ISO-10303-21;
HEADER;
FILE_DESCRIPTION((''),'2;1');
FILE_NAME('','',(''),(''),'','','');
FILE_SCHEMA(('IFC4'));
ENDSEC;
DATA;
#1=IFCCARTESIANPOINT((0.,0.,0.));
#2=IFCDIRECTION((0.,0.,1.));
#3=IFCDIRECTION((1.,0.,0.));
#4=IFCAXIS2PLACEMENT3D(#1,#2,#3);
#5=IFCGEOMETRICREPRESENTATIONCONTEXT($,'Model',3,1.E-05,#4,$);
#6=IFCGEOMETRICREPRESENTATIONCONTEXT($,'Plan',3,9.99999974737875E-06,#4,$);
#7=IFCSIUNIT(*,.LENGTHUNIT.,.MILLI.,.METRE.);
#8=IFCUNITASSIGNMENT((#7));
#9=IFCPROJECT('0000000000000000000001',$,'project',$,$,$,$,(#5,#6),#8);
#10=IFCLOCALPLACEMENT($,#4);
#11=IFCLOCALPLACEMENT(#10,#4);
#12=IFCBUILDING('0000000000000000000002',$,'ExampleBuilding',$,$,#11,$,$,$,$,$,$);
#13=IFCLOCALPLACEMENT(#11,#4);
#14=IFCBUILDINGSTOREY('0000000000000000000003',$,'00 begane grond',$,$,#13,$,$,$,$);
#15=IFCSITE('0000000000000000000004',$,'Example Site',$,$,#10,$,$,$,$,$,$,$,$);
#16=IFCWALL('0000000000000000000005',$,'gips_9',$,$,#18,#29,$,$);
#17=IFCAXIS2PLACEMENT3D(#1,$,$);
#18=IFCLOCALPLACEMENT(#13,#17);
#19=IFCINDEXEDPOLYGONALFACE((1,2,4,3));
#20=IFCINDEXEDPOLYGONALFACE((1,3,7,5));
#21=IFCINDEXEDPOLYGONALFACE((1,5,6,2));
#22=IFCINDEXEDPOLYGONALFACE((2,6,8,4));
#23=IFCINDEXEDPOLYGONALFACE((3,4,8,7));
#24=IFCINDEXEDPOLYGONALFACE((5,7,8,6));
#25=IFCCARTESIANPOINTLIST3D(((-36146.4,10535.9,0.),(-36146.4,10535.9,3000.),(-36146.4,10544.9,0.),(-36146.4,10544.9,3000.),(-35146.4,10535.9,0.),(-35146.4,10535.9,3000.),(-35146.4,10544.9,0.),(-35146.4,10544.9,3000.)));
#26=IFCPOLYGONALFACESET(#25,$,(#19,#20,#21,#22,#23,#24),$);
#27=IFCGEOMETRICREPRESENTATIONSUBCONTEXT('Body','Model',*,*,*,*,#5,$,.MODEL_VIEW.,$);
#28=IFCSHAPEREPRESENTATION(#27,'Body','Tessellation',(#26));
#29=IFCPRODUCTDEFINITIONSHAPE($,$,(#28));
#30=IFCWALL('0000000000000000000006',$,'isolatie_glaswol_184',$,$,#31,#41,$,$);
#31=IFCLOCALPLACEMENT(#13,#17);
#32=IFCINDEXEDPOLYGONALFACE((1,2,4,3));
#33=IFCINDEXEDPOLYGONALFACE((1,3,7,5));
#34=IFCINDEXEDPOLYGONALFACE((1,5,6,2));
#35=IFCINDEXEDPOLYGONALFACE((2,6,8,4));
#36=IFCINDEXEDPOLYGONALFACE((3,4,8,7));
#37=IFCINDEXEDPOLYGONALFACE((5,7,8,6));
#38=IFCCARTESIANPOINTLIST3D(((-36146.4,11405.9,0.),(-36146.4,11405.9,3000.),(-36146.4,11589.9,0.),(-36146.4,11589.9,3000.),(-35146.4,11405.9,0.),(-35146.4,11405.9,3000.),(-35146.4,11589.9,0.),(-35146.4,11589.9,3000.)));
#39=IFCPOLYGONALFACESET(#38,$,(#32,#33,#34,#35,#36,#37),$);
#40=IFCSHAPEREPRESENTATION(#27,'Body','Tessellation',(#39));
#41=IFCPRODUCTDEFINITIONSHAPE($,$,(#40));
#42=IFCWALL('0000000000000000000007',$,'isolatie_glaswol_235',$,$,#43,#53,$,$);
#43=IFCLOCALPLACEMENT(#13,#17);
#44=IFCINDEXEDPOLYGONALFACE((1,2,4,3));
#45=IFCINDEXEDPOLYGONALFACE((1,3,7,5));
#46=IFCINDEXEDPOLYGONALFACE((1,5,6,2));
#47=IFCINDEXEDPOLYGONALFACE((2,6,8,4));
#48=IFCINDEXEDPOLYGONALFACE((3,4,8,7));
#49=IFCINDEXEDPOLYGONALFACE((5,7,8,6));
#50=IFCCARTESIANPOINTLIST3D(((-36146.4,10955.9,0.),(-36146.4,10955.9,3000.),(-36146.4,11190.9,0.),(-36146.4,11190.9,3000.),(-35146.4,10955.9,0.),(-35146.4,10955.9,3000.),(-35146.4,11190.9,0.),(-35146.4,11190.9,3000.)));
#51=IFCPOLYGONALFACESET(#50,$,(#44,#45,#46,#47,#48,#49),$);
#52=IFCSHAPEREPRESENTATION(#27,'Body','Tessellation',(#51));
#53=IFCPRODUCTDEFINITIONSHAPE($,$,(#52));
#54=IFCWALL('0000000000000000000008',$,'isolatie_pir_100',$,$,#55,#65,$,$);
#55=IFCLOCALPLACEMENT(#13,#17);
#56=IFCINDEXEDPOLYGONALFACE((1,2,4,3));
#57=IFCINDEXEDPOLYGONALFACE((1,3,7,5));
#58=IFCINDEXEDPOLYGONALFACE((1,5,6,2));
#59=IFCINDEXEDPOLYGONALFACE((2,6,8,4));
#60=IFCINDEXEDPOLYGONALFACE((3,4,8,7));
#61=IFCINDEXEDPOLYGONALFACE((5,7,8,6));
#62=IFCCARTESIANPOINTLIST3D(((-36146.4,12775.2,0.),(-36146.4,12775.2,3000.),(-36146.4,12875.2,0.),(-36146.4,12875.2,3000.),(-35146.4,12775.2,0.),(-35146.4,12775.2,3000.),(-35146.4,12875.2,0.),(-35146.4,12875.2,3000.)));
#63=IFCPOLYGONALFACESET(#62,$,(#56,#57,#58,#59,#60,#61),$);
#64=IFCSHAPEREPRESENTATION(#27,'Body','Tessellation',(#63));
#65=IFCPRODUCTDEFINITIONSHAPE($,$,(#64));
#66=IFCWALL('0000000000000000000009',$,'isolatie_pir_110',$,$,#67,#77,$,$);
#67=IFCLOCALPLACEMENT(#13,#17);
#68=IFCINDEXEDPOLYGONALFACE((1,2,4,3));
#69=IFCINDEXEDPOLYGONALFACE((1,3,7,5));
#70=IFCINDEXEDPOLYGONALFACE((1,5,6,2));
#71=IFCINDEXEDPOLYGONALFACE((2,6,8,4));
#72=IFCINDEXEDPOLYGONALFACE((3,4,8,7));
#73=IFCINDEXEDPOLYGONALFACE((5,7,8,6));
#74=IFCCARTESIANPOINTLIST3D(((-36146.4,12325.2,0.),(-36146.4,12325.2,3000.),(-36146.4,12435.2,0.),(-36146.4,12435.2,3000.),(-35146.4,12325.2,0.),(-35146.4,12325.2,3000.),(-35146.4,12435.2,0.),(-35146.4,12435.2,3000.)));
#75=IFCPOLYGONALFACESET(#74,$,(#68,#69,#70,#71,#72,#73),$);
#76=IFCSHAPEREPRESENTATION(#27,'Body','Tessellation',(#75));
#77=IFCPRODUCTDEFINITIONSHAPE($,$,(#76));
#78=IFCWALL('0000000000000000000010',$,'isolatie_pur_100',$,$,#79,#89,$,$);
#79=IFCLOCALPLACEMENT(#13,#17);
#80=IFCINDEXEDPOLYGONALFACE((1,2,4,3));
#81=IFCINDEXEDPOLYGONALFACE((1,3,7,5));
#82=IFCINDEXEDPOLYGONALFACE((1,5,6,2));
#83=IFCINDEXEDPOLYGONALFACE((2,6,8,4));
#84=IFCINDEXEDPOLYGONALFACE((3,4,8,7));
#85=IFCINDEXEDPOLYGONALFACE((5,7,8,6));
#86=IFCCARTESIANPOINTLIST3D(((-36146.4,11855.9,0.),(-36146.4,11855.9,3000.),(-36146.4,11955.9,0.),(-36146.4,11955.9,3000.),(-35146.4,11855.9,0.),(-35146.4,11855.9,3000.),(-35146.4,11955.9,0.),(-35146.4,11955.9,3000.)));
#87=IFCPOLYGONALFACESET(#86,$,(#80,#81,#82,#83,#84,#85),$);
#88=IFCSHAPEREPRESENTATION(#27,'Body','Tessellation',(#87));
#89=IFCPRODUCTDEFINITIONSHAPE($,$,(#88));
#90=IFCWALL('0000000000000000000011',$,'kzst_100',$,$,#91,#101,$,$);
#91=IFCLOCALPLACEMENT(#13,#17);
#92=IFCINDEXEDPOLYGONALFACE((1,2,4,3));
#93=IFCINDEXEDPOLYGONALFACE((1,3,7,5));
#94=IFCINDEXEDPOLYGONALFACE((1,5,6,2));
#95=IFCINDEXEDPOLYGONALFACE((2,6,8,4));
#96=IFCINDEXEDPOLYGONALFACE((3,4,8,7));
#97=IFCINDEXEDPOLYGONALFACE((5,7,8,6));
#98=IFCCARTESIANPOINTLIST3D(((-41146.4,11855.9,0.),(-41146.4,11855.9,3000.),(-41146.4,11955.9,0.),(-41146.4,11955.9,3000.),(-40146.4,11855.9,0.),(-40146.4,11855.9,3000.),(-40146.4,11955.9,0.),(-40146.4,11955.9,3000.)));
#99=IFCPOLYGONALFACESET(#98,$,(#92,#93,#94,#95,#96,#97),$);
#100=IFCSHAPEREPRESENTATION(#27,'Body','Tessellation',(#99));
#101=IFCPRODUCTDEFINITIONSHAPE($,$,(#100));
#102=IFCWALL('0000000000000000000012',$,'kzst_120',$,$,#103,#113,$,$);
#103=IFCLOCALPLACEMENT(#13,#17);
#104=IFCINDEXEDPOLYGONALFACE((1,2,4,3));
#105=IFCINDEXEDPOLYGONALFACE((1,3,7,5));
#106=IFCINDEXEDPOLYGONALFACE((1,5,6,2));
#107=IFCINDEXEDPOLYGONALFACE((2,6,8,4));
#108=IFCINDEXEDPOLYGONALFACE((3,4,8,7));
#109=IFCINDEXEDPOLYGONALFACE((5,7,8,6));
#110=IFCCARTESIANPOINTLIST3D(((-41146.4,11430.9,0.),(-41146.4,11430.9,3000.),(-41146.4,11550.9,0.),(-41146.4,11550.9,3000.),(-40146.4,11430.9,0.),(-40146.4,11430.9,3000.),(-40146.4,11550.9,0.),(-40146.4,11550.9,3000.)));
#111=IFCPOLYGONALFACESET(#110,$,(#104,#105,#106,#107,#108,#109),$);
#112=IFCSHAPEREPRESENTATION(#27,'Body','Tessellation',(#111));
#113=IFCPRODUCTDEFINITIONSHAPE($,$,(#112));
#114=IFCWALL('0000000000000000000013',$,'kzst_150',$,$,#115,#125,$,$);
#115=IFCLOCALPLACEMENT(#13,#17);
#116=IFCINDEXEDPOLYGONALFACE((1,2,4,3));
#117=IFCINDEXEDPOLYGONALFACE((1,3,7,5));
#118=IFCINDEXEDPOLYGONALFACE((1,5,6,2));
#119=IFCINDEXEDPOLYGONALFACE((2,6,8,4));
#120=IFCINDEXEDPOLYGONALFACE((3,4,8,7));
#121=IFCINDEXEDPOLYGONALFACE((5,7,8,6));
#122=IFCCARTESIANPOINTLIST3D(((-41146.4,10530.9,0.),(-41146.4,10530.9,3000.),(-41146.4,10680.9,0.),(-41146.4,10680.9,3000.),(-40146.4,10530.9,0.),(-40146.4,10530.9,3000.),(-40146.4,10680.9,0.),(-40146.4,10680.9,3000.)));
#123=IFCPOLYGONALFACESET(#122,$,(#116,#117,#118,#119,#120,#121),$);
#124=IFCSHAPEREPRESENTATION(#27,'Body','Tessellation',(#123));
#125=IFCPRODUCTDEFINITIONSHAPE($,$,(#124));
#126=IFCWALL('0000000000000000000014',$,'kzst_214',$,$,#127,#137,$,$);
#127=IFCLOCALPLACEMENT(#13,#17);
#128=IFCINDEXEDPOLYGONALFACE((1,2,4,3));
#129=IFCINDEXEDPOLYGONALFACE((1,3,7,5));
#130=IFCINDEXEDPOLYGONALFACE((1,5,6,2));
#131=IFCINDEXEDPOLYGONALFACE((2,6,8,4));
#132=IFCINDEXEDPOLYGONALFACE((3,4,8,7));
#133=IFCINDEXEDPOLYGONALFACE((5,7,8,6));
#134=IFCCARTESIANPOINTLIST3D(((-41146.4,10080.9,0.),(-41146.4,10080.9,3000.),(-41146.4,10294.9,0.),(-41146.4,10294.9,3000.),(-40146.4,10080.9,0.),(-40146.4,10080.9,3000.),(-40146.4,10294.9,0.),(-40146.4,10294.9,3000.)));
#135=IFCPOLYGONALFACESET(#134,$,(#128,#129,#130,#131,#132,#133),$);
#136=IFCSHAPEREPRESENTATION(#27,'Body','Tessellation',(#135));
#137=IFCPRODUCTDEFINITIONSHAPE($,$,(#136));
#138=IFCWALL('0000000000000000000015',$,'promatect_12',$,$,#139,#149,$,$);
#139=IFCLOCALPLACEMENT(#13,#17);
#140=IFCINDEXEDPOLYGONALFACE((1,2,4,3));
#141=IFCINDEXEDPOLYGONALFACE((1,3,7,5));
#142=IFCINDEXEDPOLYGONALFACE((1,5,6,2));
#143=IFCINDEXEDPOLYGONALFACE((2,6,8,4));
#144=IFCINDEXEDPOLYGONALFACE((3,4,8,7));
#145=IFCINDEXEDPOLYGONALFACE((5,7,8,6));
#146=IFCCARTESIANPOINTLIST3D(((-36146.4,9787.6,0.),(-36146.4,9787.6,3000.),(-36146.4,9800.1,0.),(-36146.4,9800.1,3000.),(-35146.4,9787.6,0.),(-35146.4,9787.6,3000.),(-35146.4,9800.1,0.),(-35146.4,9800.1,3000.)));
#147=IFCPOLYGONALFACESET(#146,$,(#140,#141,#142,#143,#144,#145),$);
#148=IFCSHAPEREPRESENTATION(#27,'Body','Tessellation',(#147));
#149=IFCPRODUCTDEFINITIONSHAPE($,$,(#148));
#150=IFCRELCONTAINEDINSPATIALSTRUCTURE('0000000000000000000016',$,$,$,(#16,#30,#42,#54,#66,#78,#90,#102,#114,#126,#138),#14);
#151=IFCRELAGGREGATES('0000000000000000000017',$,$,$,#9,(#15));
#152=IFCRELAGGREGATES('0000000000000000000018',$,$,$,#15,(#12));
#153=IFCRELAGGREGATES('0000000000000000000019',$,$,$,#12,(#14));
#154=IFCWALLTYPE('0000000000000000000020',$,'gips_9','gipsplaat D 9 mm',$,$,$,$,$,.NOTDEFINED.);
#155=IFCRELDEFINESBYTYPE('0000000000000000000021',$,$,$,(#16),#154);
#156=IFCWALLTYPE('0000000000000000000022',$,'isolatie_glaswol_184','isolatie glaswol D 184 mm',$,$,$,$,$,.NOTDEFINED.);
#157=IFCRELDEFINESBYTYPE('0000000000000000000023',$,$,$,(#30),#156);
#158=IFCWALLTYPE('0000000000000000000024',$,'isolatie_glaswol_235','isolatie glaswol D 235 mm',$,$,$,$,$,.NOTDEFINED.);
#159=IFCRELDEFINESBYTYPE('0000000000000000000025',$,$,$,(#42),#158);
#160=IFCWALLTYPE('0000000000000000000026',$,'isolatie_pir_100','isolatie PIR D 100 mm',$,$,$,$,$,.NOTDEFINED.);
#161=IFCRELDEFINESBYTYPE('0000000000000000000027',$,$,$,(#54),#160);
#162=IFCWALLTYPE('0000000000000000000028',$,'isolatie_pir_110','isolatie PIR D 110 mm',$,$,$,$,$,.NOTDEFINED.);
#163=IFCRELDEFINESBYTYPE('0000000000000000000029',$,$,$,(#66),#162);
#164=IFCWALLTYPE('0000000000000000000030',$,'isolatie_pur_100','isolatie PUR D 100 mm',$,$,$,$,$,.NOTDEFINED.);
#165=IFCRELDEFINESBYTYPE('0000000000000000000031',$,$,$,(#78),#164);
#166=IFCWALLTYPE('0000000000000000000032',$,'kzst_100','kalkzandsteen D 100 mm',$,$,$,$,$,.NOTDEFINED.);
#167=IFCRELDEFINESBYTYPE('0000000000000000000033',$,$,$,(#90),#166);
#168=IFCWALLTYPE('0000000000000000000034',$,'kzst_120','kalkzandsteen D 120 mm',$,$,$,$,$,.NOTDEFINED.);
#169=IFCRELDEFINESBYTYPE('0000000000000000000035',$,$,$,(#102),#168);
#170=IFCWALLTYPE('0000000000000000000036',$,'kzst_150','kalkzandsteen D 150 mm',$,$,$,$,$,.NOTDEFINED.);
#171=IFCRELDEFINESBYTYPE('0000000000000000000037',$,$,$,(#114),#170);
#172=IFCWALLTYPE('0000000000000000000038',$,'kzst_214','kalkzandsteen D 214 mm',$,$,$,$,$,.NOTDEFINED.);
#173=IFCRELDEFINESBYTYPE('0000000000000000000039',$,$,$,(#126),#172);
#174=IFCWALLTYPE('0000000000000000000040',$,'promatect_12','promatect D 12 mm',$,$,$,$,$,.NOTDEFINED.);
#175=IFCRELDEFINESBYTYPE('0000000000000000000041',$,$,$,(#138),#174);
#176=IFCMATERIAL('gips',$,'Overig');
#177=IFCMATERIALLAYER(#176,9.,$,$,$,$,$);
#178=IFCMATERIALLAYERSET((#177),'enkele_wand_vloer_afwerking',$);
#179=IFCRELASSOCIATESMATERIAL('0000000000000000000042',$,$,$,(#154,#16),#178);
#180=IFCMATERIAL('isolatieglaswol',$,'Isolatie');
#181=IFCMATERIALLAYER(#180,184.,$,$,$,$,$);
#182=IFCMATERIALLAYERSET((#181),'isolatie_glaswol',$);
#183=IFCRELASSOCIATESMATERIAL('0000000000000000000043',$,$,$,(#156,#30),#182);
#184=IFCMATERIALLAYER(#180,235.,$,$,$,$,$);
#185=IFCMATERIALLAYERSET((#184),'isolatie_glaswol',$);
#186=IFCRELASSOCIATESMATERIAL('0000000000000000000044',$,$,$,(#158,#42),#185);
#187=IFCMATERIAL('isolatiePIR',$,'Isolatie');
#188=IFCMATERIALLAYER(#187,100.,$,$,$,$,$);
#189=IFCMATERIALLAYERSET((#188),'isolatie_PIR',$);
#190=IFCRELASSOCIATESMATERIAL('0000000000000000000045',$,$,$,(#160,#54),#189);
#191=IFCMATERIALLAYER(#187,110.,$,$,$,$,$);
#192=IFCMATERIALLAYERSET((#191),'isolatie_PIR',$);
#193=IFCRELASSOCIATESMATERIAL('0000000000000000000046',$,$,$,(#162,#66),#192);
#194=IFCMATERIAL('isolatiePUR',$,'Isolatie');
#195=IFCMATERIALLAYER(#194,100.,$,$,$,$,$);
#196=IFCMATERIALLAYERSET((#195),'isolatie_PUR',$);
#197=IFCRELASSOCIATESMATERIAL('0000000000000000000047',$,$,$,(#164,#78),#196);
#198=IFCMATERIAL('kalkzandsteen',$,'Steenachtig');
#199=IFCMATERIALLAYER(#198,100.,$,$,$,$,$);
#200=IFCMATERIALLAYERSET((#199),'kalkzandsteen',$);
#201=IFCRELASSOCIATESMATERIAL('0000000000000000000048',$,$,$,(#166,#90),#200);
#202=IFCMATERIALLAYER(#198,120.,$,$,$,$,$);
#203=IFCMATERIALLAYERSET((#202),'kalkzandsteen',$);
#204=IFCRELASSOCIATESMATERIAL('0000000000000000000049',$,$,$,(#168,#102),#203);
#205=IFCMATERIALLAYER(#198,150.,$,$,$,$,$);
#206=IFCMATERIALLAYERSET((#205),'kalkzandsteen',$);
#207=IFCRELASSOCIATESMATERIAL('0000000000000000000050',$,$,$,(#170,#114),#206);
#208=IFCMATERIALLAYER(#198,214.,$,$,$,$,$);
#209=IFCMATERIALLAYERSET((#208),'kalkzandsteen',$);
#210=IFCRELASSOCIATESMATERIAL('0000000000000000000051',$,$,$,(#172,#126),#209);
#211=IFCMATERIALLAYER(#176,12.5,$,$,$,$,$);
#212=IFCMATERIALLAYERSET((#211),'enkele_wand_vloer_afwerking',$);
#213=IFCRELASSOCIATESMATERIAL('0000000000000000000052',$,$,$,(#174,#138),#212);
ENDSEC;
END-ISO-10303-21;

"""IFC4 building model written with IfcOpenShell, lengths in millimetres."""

from ifc_helpers import new_model, si_unit, frame, origin_with_axes, place, context, subcontext, project, spatial, indexed_curve, outline, extrude, material, layer, layer_set, layer_usage, type_object, element, save


model = new_model("IFC4")

# Units and contexts
model_context = context("Model", 3, precision=1e-05, world=origin_with_axes())
plan_context = context("Plan", 3, precision=9.99999974737875e-06, world=origin_with_axes())
body_context = subcontext(model_context, "Body", "Model", "MODEL_VIEW")
ifc_project = project(units=[si_unit("LENGTHUNIT", "METRE", prefix="MILLI")], contexts=[model_context, plan_context])

# Site, building, storey
site_placement = place(None, frame((0.0, 0.0, 0.0), z_axis=(0.0, 0.0, 1.0), x_axis=(1.0, 0.0, 0.0)))
site = spatial("IfcSite", under=ifc_project, at=site_placement, Name="Example Site")
building_placement = place(site_placement, frame((0.0, 0.0, 0.0), z_axis=(0.0, 0.0, 1.0), x_axis=(1.0, 0.0, 0.0)))
building = spatial("IfcBuilding", under=site, at=building_placement, Name="ExampleBuilding")
storey_placement = place(building_placement, frame((0.0, 0.0, 0.0), z_axis=(0.0, 0.0, 1.0), x_axis=(1.0, 0.0, 0.0)))
storey = spatial("IfcBuildingStorey", under=building, at=storey_placement, Name="00 begane grond")

# Walls
ifc_material_1 = material(Name="gips", Category="Overig")
ifc_layer_1 = layer(ifc_material_1, 9.0)
ifc_layer_set_1 = layer_set([ifc_layer_1], Name="enkele_wand_vloer_afwerking")
ifc_layer_usage_1 = layer_usage(ifc_layer_set_1, "AXIS2", "POSITIVE", 0.0)
wall_type_1 = type_object("IfcWallType", Name="gips_9", Description="gipsplaat D 9 mm", PredefinedType="NOTDEFINED", material=ifc_layer_set_1)
wall_1_placement = place(storey_placement, frame((-36146.4, 10535.9, 0.0), z_axis=(0.0, 0.0, 1.0), x_axis=(1.0, 0.0, 0.0)))
element("IfcWall", 1, at=wall_1_placement, inside=storey, type_object=wall_type_1, material=ifc_layer_usage_1, Name="gips_9", context=body_context, shape_type="SweptSolid", body=[
    extrude(outline(indexed_curve([(0.0, 0.0), (0.0, 9.0), (1000.0, 9.0), (1000.0, 0.0), (0.0, 0.0)], self_intersect=False)), origin_with_axes(), (0.0, 0.0, 1.0), 3000.0),
])
ifc_material_2 = material(Name="isolatieglaswol", Category="Isolatie")
ifc_layer_2 = layer(ifc_material_2, 184.0)
ifc_layer_set_2 = layer_set([ifc_layer_2], Name="isolatie_glaswol")
ifc_layer_usage_2 = layer_usage(ifc_layer_set_2, "AXIS2", "POSITIVE", 0.0)
wall_type_2 = type_object("IfcWallType", Name="isolatie_glaswol_184", Description="isolatie glaswol D 184 mm", PredefinedType="NOTDEFINED", material=ifc_layer_set_2)
wall_2_placement = place(storey_placement, frame((-36146.4, 11405.9, 0.0), z_axis=(0.0, 0.0, 1.0), x_axis=(1.0, 0.0, 0.0)))
element("IfcWall", 2, at=wall_2_placement, inside=storey, type_object=wall_type_2, material=ifc_layer_usage_2, Name="isolatie_glaswol_184", context=body_context, shape_type="SweptSolid", body=[
    extrude(outline(indexed_curve([(0.0, 0.0), (0.0, 184.0), (1000.0, 184.0), (1000.0, 0.0), (0.0, 0.0)], self_intersect=False)), origin_with_axes(), (0.0, 0.0, 1.0), 3000.0),
])
ifc_layer_3 = layer(ifc_material_2, 235.0)
ifc_layer_set_3 = layer_set([ifc_layer_3], Name="isolatie_glaswol")
ifc_layer_usage_3 = layer_usage(ifc_layer_set_3, "AXIS2", "POSITIVE", 0.0)
wall_type_3 = type_object("IfcWallType", Name="isolatie_glaswol_235", Description="isolatie glaswol D 235 mm", PredefinedType="NOTDEFINED", material=ifc_layer_set_3)
wall_3_placement = place(storey_placement, frame((-36146.4, 10955.9, 0.0), z_axis=(0.0, 0.0, 1.0), x_axis=(1.0, 0.0, 0.0)))
element("IfcWall", 3, at=wall_3_placement, inside=storey, type_object=wall_type_3, material=ifc_layer_usage_3, Name="isolatie_glaswol_235", context=body_context, shape_type="SweptSolid", body=[
    extrude(outline(indexed_curve([(0.0, 0.0), (0.0, 235.0), (1000.0, 235.0), (1000.0, 0.0), (0.0, 0.0)], self_intersect=False)), origin_with_axes(), (0.0, 0.0, 1.0), 3000.0),
])
ifc_material_3 = material(Name="isolatiePIR", Category="Isolatie")
ifc_layer_4 = layer(ifc_material_3, 100.0)
ifc_layer_set_4 = layer_set([ifc_layer_4], Name="isolatie_PIR")
ifc_layer_usage_4 = layer_usage(ifc_layer_set_4, "AXIS2", "POSITIVE", 0.0)
wall_type_4 = type_object("IfcWallType", Name="isolatie_pir_100", Description="isolatie PIR D 100 mm", PredefinedType="NOTDEFINED", material=ifc_layer_set_4)
wall_4_placement = place(storey_placement, frame((-36146.4, 12775.2, 0.0), z_axis=(0.0, 0.0, 1.0), x_axis=(1.0, 0.0, 0.0)))
element("IfcWall", 4, at=wall_4_placement, inside=storey, type_object=wall_type_4, material=ifc_layer_usage_4, Name="isolatie_pir_100", context=body_context, shape_type="SweptSolid", body=[
    extrude(outline(indexed_curve([(0.0, 0.0), (0.0, 100.0), (1000.0, 100.0), (1000.0, 0.0), (0.0, 0.0)], self_intersect=False)), origin_with_axes(), (0.0, 0.0, 1.0), 3000.0),
])
ifc_layer_5 = layer(ifc_material_3, 110.0)
ifc_layer_set_5 = layer_set([ifc_layer_5], Name="isolatie_PIR")
ifc_layer_usage_5 = layer_usage(ifc_layer_set_5, "AXIS2", "POSITIVE", 0.0)
wall_type_5 = type_object("IfcWallType", Name="isolatie_pir_110", Description="isolatie PIR D 110 mm", PredefinedType="NOTDEFINED", material=ifc_layer_set_5)
wall_5_placement = place(storey_placement, frame((-36146.4, 12325.2, 0.0), z_axis=(0.0, 0.0, 1.0), x_axis=(1.0, 0.0, 0.0)))
element("IfcWall", 5, at=wall_5_placement, inside=storey, type_object=wall_type_5, material=ifc_layer_usage_5, Name="isolatie_pir_110", context=body_context, shape_type="SweptSolid", body=[
    extrude(outline(indexed_curve([(0.0, 0.0), (0.0, 110.0), (1000.0, 110.0), (1000.0, 0.0), (0.0, 0.0)], self_intersect=False)), origin_with_axes(), (0.0, 0.0, 1.0), 3000.0),
])
ifc_material_4 = material(Name="isolatiePUR", Category="Isolatie")
ifc_layer_6 = layer(ifc_material_4, 100.0)
ifc_layer_set_6 = layer_set([ifc_layer_6], Name="isolatie_PUR")
ifc_layer_usage_6 = layer_usage(ifc_layer_set_6, "AXIS2", "POSITIVE", 0.0)
wall_type_6 = type_object("IfcWallType", Name="isolatie_pur_100", Description="isolatie PUR D 100 mm", PredefinedType="NOTDEFINED", material=ifc_layer_set_6)
wall_6_placement = place(storey_placement, frame((-36146.4, 11855.9, 0.0), z_axis=(0.0, 0.0, 1.0), x_axis=(1.0, 0.0, 0.0)))
element("IfcWall", 6, at=wall_6_placement, inside=storey, type_object=wall_type_6, material=ifc_layer_usage_6, Name="isolatie_pur_100", context=body_context, shape_type="SweptSolid", body=[
    extrude(outline(indexed_curve([(0.0, 0.0), (0.0, 100.0), (1000.0, 100.0), (1000.0, 0.0), (0.0, 0.0)], self_intersect=False)), origin_with_axes(), (0.0, 0.0, 1.0), 3000.0),
])
ifc_material_5 = material(Name="kalkzandsteen", Category="Steenachtig")
ifc_layer_7 = layer(ifc_material_5, 100.0)
ifc_layer_set_7 = layer_set([ifc_layer_7], Name="kalkzandsteen")
ifc_layer_usage_7 = layer_usage(ifc_layer_set_7, "AXIS2", "POSITIVE", 0.0)
wall_type_7 = type_object("IfcWallType", Name="kzst_100", Description="kalkzandsteen D 100 mm", PredefinedType="NOTDEFINED", material=ifc_layer_set_7)
wall_7_placement = place(storey_placement, frame((-41146.4, 11855.9, 0.0), z_axis=(0.0, 0.0, 1.0), x_axis=(1.0, 0.0, 0.0)))
element("IfcWall", 7, at=wall_7_placement, inside=storey, type_object=wall_type_7, material=ifc_layer_usage_7, Name="kzst_100", context=body_context, shape_type="SweptSolid", body=[
    extrude(outline(indexed_curve([(0.0, 0.0), (0.0, 100.0), (1000.0, 100.0), (1000.0, 0.0), (0.0, 0.0)], self_intersect=False)), origin_with_axes(), (0.0, 0.0, 1.0), 3000.0),
])
ifc_layer_8 = layer(ifc_material_5, 120.0)
ifc_layer_set_8 = layer_set([ifc_layer_8], Name="kalkzandsteen")
ifc_layer_usage_8 = layer_usage(ifc_layer_set_8, "AXIS2", "POSITIVE", 0.0)
wall_type_8 = type_object("IfcWallType", Name="kzst_120", Description="kalkzandsteen D 120 mm", PredefinedType="NOTDEFINED", material=ifc_layer_set_8)
wall_8_placement = place(storey_placement, frame((-41146.4, 11430.9, 0.0), z_axis=(0.0, 0.0, 1.0), x_axis=(1.0, 0.0, 0.0)))
element("IfcWall", 8, at=wall_8_placement, inside=storey, type_object=wall_type_8, material=ifc_layer_usage_8, Name="kzst_120", context=body_context, shape_type="SweptSolid", body=[
    extrude(outline(indexed_curve([(0.0, 0.0), (0.0, 120.0), (1000.0, 120.0), (1000.0, 0.0), (0.0, 0.0)], self_intersect=False)), origin_with_axes(), (0.0, 0.0, 1.0), 3000.0),
])
ifc_layer_9 = layer(ifc_material_5, 150.0)
ifc_layer_set_9 = layer_set([ifc_layer_9], Name="kalkzandsteen")
ifc_layer_usage_9 = layer_usage(ifc_layer_set_9, "AXIS2", "POSITIVE", 0.0)
wall_type_9 = type_object("IfcWallType", Name="kzst_150", Description="kalkzandsteen D 150 mm", PredefinedType="NOTDEFINED", material=ifc_layer_set_9)
wall_9_placement = place(storey_placement, frame((-41146.4, 10530.9, 0.0), z_axis=(0.0, 0.0, 1.0), x_axis=(1.0, 0.0, 0.0)))
element("IfcWall", 9, at=wall_9_placement, inside=storey, type_object=wall_type_9, material=ifc_layer_usage_9, Name="kzst_150", context=body_context, shape_type="SweptSolid", body=[
    extrude(outline(indexed_curve([(0.0, 0.0), (0.0, 150.0), (1000.0, 150.0), (1000.0, 0.0), (0.0, 0.0)], self_intersect=False)), origin_with_axes(), (0.0, 0.0, 1.0), 3000.0),
])
ifc_layer_10 = layer(ifc_material_5, 214.0)
ifc_layer_set_10 = layer_set([ifc_layer_10], Name="kalkzandsteen")
ifc_layer_usage_10 = layer_usage(ifc_layer_set_10, "AXIS2", "POSITIVE", 0.0)
wall_type_10 = type_object("IfcWallType", Name="kzst_214", Description="kalkzandsteen D 214 mm", PredefinedType="NOTDEFINED", material=ifc_layer_set_10)
wall_10_placement = place(storey_placement, frame((-41146.4, 10080.9, 0.0), z_axis=(0.0, 0.0, 1.0), x_axis=(1.0, 0.0, 0.0)))
element("IfcWall", 10, at=wall_10_placement, inside=storey, type_object=wall_type_10, material=ifc_layer_usage_10, Name="kzst_214", context=body_context, shape_type="SweptSolid", body=[
    extrude(outline(indexed_curve([(0.0, 0.0), (0.0, 214.0), (1000.0, 214.0), (1000.0, 0.0), (0.0, 0.0)], self_intersect=False)), origin_with_axes(), (0.0, 0.0, 1.0), 3000.0),
])
ifc_layer_11 = layer(ifc_material_1, 12.5)
ifc_layer_set_11 = layer_set([ifc_layer_11], Name="enkele_wand_vloer_afwerking")
ifc_layer_usage_11 = layer_usage(ifc_layer_set_11, "AXIS2", "POSITIVE", 0.0)
wall_type_11 = type_object("IfcWallType", Name="promatect_12", Description="promatect D 12 mm", PredefinedType="NOTDEFINED", material=ifc_layer_set_11)
wall_11_placement = place(storey_placement, frame((-36146.4, 9787.6, 0.0), z_axis=(0.0, 0.0, 1.0), x_axis=(1.0, 0.0, 0.0)))
element("IfcWall", 11, at=wall_11_placement, inside=storey, type_object=wall_type_11, material=ifc_layer_usage_11, Name="promatect_12", context=body_context, shape_type="SweptSolid", body=[
    extrude(outline(indexed_curve([(0.0, 0.0), (0.0, 12.5), (1000.0, 12.5), (1000.0, 0.0), (0.0, 0.0)], self_intersect=False)), origin_with_axes(), (0.0, 0.0, 1.0), 3000.0),
])

save(model, "model.ifc")
